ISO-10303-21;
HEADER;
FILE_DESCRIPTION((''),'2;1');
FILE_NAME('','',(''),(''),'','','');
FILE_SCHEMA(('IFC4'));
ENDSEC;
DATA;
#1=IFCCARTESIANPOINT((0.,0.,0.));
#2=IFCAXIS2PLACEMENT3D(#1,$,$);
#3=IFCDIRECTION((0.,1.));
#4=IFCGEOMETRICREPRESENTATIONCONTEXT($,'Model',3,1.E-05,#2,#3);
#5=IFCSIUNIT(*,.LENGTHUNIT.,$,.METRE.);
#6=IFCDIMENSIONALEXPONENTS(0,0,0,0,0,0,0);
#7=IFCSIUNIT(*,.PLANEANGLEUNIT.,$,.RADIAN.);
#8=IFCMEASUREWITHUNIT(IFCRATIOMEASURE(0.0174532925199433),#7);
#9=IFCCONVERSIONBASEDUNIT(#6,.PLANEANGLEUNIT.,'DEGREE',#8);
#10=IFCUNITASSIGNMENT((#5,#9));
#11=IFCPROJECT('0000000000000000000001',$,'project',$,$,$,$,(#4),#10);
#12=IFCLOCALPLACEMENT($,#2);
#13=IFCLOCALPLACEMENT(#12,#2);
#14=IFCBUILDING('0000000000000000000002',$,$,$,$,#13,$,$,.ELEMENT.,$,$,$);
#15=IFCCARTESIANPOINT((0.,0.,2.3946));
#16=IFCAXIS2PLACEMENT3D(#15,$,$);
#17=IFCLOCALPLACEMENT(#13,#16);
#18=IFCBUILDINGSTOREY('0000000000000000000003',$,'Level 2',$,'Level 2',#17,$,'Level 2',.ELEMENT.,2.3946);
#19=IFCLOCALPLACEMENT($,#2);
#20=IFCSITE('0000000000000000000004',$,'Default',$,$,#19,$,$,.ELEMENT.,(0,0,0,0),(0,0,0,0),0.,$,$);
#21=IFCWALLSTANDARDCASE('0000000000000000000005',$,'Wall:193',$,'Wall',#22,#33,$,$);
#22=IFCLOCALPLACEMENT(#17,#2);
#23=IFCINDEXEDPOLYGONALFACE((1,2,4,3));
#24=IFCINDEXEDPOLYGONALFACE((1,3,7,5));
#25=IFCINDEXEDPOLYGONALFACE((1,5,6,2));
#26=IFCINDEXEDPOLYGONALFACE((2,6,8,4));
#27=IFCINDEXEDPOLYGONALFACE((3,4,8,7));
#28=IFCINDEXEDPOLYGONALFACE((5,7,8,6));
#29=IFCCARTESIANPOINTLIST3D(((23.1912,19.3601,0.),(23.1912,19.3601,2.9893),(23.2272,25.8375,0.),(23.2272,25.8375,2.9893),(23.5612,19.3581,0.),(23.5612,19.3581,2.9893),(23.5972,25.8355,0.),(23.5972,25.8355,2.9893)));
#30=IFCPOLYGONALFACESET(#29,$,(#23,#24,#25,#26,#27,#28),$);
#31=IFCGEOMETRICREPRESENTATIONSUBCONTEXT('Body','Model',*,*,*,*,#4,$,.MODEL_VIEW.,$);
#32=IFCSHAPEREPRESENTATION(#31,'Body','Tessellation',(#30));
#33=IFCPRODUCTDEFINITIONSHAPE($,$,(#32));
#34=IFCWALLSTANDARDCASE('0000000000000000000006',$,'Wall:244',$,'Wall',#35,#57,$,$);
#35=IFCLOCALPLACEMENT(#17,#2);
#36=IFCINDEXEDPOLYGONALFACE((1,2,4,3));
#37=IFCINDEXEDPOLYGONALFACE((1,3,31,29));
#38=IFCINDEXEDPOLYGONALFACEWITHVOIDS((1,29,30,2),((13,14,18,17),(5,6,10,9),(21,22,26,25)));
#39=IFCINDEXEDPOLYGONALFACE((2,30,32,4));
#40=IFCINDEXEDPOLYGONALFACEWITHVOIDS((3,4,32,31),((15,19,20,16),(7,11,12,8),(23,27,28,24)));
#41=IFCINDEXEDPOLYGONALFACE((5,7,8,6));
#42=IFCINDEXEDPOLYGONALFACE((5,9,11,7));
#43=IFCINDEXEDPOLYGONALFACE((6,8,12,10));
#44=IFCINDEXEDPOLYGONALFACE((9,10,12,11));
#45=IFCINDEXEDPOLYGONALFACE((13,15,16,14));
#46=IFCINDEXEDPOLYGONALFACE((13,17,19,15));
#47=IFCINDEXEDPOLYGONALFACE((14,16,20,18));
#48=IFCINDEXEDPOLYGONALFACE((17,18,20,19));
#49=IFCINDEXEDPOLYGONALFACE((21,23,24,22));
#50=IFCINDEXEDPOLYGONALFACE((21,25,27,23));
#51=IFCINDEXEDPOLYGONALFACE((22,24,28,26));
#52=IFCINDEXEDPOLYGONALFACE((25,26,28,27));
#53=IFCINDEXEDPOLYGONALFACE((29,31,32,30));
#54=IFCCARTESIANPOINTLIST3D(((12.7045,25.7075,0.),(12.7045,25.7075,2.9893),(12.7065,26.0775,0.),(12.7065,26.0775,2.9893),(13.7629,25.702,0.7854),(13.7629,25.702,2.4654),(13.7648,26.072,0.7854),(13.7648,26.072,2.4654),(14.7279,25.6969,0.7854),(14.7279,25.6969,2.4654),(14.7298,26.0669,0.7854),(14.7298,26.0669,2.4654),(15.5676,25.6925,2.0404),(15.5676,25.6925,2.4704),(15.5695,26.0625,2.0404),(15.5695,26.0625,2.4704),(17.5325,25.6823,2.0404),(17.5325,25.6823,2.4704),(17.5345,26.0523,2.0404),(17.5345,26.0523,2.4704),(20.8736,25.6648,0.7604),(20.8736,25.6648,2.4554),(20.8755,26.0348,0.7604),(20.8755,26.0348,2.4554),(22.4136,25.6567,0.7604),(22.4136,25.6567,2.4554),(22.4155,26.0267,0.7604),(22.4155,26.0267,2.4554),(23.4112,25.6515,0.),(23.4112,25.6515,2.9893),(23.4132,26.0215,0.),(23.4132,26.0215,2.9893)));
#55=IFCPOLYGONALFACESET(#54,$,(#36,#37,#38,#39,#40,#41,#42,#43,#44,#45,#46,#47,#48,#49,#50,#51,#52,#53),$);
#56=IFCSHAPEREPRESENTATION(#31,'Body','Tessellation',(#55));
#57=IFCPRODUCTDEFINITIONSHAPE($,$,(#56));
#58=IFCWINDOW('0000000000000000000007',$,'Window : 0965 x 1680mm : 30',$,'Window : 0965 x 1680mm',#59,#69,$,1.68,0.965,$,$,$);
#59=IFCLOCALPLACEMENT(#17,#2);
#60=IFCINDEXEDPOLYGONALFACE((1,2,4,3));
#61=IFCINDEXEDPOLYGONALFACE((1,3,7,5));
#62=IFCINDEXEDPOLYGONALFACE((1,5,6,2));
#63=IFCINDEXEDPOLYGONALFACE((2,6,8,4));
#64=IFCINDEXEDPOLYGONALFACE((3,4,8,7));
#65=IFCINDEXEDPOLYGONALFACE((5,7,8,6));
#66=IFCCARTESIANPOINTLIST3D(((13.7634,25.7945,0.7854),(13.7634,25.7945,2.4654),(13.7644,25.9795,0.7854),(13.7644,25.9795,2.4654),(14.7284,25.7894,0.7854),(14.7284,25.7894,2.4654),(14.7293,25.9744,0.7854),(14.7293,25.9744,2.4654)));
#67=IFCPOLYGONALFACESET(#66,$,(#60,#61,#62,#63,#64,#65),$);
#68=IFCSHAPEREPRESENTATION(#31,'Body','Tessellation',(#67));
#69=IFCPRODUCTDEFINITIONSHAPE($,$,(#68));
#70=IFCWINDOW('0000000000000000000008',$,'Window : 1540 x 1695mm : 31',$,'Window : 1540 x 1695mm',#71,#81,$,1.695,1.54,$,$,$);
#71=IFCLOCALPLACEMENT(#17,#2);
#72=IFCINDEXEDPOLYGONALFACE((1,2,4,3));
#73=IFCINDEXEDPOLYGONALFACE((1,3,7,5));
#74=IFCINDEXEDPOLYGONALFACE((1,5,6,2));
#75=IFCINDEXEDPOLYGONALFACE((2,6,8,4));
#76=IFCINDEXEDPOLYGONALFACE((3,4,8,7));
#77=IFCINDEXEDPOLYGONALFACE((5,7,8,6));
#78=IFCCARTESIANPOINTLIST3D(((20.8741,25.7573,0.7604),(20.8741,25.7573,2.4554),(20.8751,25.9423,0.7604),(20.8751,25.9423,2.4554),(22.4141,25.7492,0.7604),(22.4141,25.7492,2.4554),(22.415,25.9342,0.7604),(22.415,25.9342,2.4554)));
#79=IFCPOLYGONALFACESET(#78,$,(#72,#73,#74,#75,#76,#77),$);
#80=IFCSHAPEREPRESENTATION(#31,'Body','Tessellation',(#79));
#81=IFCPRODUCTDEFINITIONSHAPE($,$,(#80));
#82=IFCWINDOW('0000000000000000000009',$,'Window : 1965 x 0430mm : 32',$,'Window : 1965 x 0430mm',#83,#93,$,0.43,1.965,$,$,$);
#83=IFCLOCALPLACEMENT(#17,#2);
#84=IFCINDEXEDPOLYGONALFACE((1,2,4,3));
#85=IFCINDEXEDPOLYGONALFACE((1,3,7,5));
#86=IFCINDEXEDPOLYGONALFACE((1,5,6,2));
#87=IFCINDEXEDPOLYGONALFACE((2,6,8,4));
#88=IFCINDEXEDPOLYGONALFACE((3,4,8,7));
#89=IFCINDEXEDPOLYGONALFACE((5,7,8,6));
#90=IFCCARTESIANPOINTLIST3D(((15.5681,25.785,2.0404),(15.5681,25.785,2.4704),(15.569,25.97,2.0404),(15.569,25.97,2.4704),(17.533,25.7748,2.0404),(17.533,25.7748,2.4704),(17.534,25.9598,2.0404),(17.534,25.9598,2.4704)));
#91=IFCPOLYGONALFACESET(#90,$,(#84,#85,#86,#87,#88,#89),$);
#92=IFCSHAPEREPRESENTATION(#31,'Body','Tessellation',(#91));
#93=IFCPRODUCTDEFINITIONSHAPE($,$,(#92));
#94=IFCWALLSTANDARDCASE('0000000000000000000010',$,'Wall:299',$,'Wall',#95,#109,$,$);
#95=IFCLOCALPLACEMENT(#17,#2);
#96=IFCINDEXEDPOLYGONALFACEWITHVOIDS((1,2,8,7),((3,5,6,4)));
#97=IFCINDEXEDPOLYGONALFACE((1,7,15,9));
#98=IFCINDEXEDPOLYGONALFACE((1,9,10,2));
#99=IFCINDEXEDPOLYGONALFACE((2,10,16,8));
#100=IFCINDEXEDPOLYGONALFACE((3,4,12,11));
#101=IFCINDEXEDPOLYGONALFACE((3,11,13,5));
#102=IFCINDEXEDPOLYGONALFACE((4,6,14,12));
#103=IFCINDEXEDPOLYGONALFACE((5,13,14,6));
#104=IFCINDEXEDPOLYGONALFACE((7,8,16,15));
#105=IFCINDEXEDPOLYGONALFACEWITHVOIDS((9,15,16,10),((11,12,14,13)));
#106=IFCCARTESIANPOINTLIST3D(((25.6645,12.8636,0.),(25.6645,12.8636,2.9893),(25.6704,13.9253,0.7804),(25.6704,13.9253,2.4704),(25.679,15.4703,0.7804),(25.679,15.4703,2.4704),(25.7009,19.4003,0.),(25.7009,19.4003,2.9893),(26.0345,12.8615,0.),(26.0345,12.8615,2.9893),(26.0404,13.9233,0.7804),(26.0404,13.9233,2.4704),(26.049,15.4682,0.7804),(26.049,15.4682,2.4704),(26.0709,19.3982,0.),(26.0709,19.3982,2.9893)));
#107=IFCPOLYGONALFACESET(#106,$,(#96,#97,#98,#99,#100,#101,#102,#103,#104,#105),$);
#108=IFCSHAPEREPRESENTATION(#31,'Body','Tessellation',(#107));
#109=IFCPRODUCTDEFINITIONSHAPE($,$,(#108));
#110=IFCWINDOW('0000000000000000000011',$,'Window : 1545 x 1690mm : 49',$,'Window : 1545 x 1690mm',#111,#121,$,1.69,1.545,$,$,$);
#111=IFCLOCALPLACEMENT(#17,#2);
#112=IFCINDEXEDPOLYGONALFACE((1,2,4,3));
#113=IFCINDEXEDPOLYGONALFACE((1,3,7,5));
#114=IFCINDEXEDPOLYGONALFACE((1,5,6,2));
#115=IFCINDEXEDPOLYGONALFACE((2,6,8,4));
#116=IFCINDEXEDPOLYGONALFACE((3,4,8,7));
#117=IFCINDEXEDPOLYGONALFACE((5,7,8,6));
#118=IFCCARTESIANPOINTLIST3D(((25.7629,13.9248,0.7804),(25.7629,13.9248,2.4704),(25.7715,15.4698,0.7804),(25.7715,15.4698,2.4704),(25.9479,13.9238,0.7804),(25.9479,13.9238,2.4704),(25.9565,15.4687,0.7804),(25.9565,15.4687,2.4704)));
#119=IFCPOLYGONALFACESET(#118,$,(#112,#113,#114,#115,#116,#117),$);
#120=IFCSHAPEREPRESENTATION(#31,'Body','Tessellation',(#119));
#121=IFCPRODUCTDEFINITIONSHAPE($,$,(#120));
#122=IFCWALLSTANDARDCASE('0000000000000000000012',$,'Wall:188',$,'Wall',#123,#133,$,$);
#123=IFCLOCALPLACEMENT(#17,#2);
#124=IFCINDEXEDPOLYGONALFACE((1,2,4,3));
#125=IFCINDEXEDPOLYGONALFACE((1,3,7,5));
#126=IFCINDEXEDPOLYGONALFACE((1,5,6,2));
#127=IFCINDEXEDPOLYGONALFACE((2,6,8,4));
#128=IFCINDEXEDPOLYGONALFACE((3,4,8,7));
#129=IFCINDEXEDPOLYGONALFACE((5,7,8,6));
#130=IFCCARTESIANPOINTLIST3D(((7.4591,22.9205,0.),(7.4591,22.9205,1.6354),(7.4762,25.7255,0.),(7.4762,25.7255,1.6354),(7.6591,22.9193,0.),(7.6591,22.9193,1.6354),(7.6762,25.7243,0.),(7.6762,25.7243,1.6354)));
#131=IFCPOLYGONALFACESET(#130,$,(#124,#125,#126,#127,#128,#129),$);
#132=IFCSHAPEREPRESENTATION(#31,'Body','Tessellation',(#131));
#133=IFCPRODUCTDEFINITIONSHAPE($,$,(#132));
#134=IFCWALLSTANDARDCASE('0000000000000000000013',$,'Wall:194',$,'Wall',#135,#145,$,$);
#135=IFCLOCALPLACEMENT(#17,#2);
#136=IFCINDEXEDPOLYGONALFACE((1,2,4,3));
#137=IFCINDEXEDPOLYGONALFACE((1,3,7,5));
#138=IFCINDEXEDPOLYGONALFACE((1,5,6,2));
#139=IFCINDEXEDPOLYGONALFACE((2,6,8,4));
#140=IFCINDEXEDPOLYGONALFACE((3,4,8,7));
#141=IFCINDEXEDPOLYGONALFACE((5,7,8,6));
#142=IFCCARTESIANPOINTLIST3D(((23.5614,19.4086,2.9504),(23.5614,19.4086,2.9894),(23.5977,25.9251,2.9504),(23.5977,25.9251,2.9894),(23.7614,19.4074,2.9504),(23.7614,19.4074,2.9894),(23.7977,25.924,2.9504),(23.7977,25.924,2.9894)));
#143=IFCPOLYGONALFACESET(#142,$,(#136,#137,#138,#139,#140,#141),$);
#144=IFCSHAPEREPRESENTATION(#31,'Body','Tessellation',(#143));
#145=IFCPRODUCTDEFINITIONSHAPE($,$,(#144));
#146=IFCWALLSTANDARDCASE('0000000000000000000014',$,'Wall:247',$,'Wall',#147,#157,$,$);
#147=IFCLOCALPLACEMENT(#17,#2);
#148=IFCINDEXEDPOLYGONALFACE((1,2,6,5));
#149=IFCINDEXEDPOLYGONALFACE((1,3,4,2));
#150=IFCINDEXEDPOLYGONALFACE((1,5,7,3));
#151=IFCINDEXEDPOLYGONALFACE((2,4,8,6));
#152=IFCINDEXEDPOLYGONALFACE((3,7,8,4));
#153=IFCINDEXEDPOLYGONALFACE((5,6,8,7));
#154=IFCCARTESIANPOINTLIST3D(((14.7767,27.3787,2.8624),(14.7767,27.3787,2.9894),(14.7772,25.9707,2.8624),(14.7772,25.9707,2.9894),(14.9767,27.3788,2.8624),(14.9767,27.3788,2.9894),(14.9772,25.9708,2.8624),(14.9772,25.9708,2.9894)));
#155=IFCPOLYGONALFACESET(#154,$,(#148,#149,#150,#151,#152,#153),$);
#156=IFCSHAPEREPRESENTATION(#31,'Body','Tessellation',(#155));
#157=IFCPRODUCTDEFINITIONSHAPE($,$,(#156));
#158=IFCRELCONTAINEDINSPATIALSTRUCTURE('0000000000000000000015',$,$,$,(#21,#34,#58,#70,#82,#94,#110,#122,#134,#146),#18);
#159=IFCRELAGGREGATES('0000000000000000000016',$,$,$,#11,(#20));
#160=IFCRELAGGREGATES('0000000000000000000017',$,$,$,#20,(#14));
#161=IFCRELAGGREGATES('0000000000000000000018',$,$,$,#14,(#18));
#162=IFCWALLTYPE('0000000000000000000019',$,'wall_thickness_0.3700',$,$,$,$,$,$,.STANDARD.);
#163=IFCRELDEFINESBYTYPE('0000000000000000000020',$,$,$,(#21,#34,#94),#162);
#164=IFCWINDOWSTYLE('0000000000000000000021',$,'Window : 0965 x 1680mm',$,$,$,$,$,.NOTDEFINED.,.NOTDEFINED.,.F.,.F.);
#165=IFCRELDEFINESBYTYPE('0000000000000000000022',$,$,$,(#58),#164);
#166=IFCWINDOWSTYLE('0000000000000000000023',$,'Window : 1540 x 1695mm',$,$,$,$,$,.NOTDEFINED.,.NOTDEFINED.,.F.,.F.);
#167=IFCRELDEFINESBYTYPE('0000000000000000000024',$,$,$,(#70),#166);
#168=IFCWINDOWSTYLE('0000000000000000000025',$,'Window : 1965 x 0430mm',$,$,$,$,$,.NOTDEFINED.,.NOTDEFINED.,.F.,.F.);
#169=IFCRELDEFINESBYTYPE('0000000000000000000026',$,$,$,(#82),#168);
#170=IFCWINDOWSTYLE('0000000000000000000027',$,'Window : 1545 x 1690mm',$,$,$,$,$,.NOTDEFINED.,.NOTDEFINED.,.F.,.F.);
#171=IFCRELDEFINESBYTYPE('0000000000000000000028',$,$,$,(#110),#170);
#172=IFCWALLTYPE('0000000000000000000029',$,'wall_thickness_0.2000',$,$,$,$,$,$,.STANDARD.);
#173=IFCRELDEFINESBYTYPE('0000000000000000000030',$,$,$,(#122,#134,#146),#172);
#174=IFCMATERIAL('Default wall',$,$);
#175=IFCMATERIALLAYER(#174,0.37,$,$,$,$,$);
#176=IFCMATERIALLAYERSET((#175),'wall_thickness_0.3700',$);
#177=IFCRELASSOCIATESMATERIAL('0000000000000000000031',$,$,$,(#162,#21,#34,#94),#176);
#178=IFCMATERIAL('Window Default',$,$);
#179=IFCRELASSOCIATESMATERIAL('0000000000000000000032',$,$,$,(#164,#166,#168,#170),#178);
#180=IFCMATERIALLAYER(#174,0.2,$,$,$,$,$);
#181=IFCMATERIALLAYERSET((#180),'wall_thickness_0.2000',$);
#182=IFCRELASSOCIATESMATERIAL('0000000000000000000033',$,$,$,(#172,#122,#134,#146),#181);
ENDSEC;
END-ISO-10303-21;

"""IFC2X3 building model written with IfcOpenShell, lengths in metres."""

from ifc_helpers import new_model, entity, si_unit, converted_unit, direction, frame, frame_2d, origin, origin_2d_with_axis, place, context, subcontext, project, spatial, polyline, rectangle, outline, extrude, source, transform, mapped, material, layer, layer_set, layer_usage, type_object, type_shapes, element, fill, save


model = new_model("IFC2X3")

# Units and contexts
model_context = context("Model", 3, precision=1e-05, world=origin(), true_north=direction((0.0, 1.0)))
body_context = subcontext(model_context, "Body", "Model", "MODEL_VIEW")
ifc_project = project(units=[si_unit("LENGTHUNIT", "METRE"), converted_unit("PLANEANGLEUNIT", "DEGREE", entity("IfcRatioMeasure", 0.0174532925199433), si_unit("PLANEANGLEUNIT", "RADIAN"), dimensions=[0, 0, 0, 0, 0, 0, 0])], contexts=[model_context])

# Site, building, storey
site_placement = place(None, origin())
site = spatial("IfcSite", under=ifc_project, at=site_placement, Name="Default", CompositionType="ELEMENT", RefLatitude=(0, 0, 0, 0), RefLongitude=(0, 0, 0, 0), RefElevation=0.0)
placement_1 = place(None, origin())
building_placement = place(placement_1, origin())
building = spatial("IfcBuilding", under=site, at=building_placement, CompositionType="ELEMENT")
storey_placement = place(building_placement, frame((0.0, 0.0, 2.3946)))
storey = spatial("IfcBuildingStorey", under=building, at=storey_placement, Name="Level 2", ObjectType="Level 2", LongName="Level 2", CompositionType="ELEMENT", Elevation=2.3946)

# Wall
ifc_material_1 = material(Name="Default wall")
ifc_layer_1 = layer(ifc_material_1, 0.37)
ifc_layer_set_1 = layer_set([ifc_layer_1], Name="wall_thickness_0.3700")
ifc_layer_usage_1 = layer_usage(ifc_layer_set_1, "AXIS2", "POSITIVE", -0.185)
wall_type_1 = type_object("IfcWallType", Name="wall_thickness_0.3700", PredefinedType="STANDARD", material=ifc_layer_set_1)
wall_1_placement = place(storey_placement, frame((23.4122, 25.8365, 0.0), z_axis=(0.0, 0.0, 1.0), x_axis=(-0.005562, -0.999985, 0.0)))
element("IfcWallStandardCase", 1, at=wall_1_placement, inside=storey, type_object=wall_type_1, material=ifc_layer_usage_1, Name="Wall:193", ObjectType="Wall", context=body_context, shape_type="SweptSolid", body=[
    extrude(outline(polyline([(6.4775, -0.185), (6.4775, 0.185), (0.0, 0.185), (0.0, -0.185), (6.4775, -0.185)])), origin(), (0.0, 0.0, 1.0), 2.9893),
])

# Wall, openings, windows
wall_2_placement = place(storey_placement, frame((12.7055, 25.8925, 0.0), z_axis=(0.0, 0.0, 1.0), x_axis=(0.999986, -0.005235, 0.0)))
wall_2 = element("IfcWallStandardCase", 2, at=wall_2_placement, inside=storey, type_object=wall_type_1, material=ifc_layer_usage_1, Name="Wall:244", ObjectType="Wall", context=body_context, shape_type="SweptSolid", body=[
    extrude(outline(polyline([(10.7069, -0.185), (10.7069, 0.185), (0.0, 0.185), (0.0, -0.185), (10.7069, -0.185)])), origin(), (0.0, 0.0, 1.0), 2.9893),
])
opening_1_placement = place(wall_2_placement, frame((1.0584, -0.185, 0.7854)))
opening_1 = element("IfcOpeningElement", 3, at=opening_1_placement, cuts=wall_2, ObjectType="Opening", context=body_context, shape_type="SweptSolid", body=[
    extrude(rectangle(XDim=0.965, YDim=1.68, at=frame_2d((0.84, 0.4825), x_axis=(0.0, 1.0))), frame((0.0, 0.0, 0.0), z_axis=(0.0, 1.0, 0.0), x_axis=(0.0, 0.0, 1.0)), (0.0, 0.0, 1.0), 0.37),
])
opening_2_placement = place(wall_2_placement, frame((8.1692, -0.185, 0.7604)))
opening_2 = element("IfcOpeningElement", 4, at=opening_2_placement, cuts=wall_2, ObjectType="Opening", context=body_context, shape_type="SweptSolid", body=[
    extrude(rectangle(XDim=1.54, YDim=1.695, at=frame_2d((0.8475, 0.77), x_axis=(0.0, 1.0))), frame((0.0, 0.0, 0.0), z_axis=(0.0, 1.0, 0.0), x_axis=(0.0, 0.0, 1.0)), (0.0, 0.0, 1.0), 0.37),
])
opening_3_placement = place(wall_2_placement, frame((2.8631, -0.185, 2.0404)))
opening_3 = element("IfcOpeningElement", 5, at=opening_3_placement, cuts=wall_2, ObjectType="Opening", context=body_context, shape_type="SweptSolid", body=[
    extrude(rectangle(XDim=1.965, YDim=0.43, at=frame_2d((0.215, 0.9825), x_axis=(0.0, 1.0))), frame((0.0, 0.0, 0.0), z_axis=(0.0, 1.0, 0.0), x_axis=(0.0, 0.0, 1.0)), (0.0, 0.0, 1.0), 0.37),
])
ifc_material_2 = material(Name="Window Default")
window_style_1 = type_object("IfcWindowStyle", Name="Window : 0965 x 1680mm", ConstructionType="NOTDEFINED", OperationType="NOTDEFINED", ParameterTakesPrecedence=False, Sizeable=False, material=ifc_material_2)
shared_shape_1 = source(origin(), body_context, "Body", "SweptSolid", [
    extrude(rectangle(XDim=0.185, YDim=0.965, at=origin_2d_with_axis()), frame((0.4825, 0.185, 0.0), z_axis=(0.0, 0.0, 1.0), x_axis=(0.0, 1.0, 0.0)), (0.0, 0.0, 1.0), 1.68),
])
type_shapes(window_style_1, [shared_shape_1])
window_1_placement = place(opening_1_placement, origin())
window_1 = element("IfcWindow", 6, at=window_1_placement, inside=storey, type_object=window_style_1, Name="Window : 0965 x 1680mm : 30", ObjectType="Window : 0965 x 1680mm", OverallHeight=1.68, OverallWidth=0.965, context=body_context, shape_type="MappedRepresentation", body=[
    mapped(shared_shape_1, transform((0.0, 0.0, 0.0), scale=1.0)),
])
fill(opening_1, window_1)
window_style_2 = type_object("IfcWindowStyle", Name="Window : 1540 x 1695mm", ConstructionType="NOTDEFINED", OperationType="NOTDEFINED", ParameterTakesPrecedence=False, Sizeable=False, material=ifc_material_2)
shared_shape_2 = source(origin(), body_context, "Body", "SweptSolid", [
    extrude(rectangle(XDim=0.185, YDim=1.54, at=origin_2d_with_axis()), frame((0.77, 0.185, 0.0), z_axis=(0.0, 0.0, 1.0), x_axis=(0.0, 1.0, 0.0)), (0.0, 0.0, 1.0), 1.695),
])
type_shapes(window_style_2, [shared_shape_2])
window_2_placement = place(opening_2_placement, origin())
window_2 = element("IfcWindow", 7, at=window_2_placement, inside=storey, type_object=window_style_2, Name="Window : 1540 x 1695mm : 31", ObjectType="Window : 1540 x 1695mm", OverallHeight=1.695, OverallWidth=1.54, context=body_context, shape_type="MappedRepresentation", body=[
    mapped(shared_shape_2, transform((0.0, 0.0, 0.0), scale=1.0)),
])
fill(opening_2, window_2)
window_style_3 = type_object("IfcWindowStyle", Name="Window : 1965 x 0430mm", ConstructionType="NOTDEFINED", OperationType="NOTDEFINED", ParameterTakesPrecedence=False, Sizeable=False, material=ifc_material_2)
shared_shape_3 = source(origin(), body_context, "Body", "SweptSolid", [
    extrude(rectangle(XDim=0.185, YDim=1.965, at=origin_2d_with_axis()), frame((0.9825, 0.185, 0.0), z_axis=(0.0, 0.0, 1.0), x_axis=(0.0, 1.0, 0.0)), (0.0, 0.0, 1.0), 0.43),
])
type_shapes(window_style_3, [shared_shape_3])
window_3_placement = place(opening_3_placement, origin())
window_3 = element("IfcWindow", 8, at=window_3_placement, inside=storey, type_object=window_style_3, Name="Window : 1965 x 0430mm : 32", ObjectType="Window : 1965 x 0430mm", OverallHeight=0.43, OverallWidth=1.965, context=body_context, shape_type="MappedRepresentation", body=[
    mapped(shared_shape_3, transform((0.0, 0.0, 0.0), scale=1.0)),
])
fill(opening_3, window_3)

# Wall, opening, window
wall_3_placement = place(storey_placement, frame((25.8859, 19.3992, 0.0), z_axis=(0.0, 0.0, 1.0), x_axis=(-0.005566, -0.999985, 0.0)))
wall_3 = element("IfcWallStandardCase", 9, at=wall_3_placement, inside=storey, type_object=wall_type_1, material=ifc_layer_usage_1, Name="Wall:299", ObjectType="Wall", context=body_context, shape_type="SweptSolid", body=[
    extrude(outline(polyline([(6.5368, -0.185), (6.5368, 0.185), (0.0, 0.185), (0.0, -0.185), (6.5368, -0.185)])), origin(), (0.0, 0.0, 1.0), 2.9893),
])
opening_4_placement = place(wall_3_placement, frame((3.93, -0.185, 0.7804)))
opening_4 = element("IfcOpeningElement", 10, at=opening_4_placement, cuts=wall_3, ObjectType="Opening", context=body_context, shape_type="SweptSolid", body=[
    extrude(rectangle(XDim=1.545, YDim=1.69, at=frame_2d((0.845, 0.7725), x_axis=(0.0, 1.0))), frame((0.0, 0.0, 0.0), z_axis=(0.0, 1.0, 0.0), x_axis=(0.0, 0.0, 1.0)), (0.0, 0.0, 1.0), 0.37),
])
window_style_4 = type_object("IfcWindowStyle", Name="Window : 1545 x 1690mm", ConstructionType="NOTDEFINED", OperationType="NOTDEFINED", ParameterTakesPrecedence=False, Sizeable=False, material=ifc_material_2)
shared_shape_4 = source(origin(), body_context, "Body", "SweptSolid", [
    extrude(rectangle(XDim=0.185, YDim=1.545, at=origin_2d_with_axis()), frame((0.7725, 0.185, 0.0), z_axis=(0.0, 0.0, 1.0), x_axis=(0.0, 1.0, 0.0)), (0.0, 0.0, 1.0), 1.69),
])
type_shapes(window_style_4, [shared_shape_4])
window_4_placement = place(opening_4_placement, origin())
window_4 = element("IfcWindow", 11, at=window_4_placement, inside=storey, type_object=window_style_4, Name="Window : 1545 x 1690mm : 49", ObjectType="Window : 1545 x 1690mm", OverallHeight=1.69, OverallWidth=1.545, context=body_context, shape_type="MappedRepresentation", body=[
    mapped(shared_shape_4, transform((0.0, 0.0, 0.0), scale=1.0)),
])
fill(opening_4, window_4)

# Walls
ifc_layer_2 = layer(ifc_material_1, 0.2)
ifc_layer_set_2 = layer_set([ifc_layer_2], Name="wall_thickness_0.2000")
ifc_layer_usage_2 = layer_usage(ifc_layer_set_2, "AXIS2", "POSITIVE", -0.1)
wall_type_2 = type_object("IfcWallType", Name="wall_thickness_0.2000", PredefinedType="STANDARD", material=ifc_layer_set_2)
wall_4_placement = place(storey_placement, frame((7.5591, 22.9199, 0.0), z_axis=(0.0, 0.0, 1.0), x_axis=(0.006081, 0.999982, 0.0)))
element("IfcWallStandardCase", 12, at=wall_4_placement, inside=storey, type_object=wall_type_2, material=ifc_layer_usage_2, Name="Wall:188", ObjectType="Wall", context=body_context, shape_type="SweptSolid", body=[
    extrude(outline(polyline([(2.805, -0.1), (2.805, 0.1), (0.0, 0.1), (0.0, -0.1), (2.805, -0.1)])), origin(), (0.0, 0.0, 1.0), 1.6354),
])
placement_2 = place(building_placement, frame((0.0, 0.0, 5.345)))
wall_5_placement = place(placement_2, frame((23.6977, 25.9246, 0.0), z_axis=(0.0, 0.0, 1.0), x_axis=(-0.005563, -0.999985, 0.0)))
element("IfcWallStandardCase", 13, at=wall_5_placement, inside=storey, type_object=wall_type_2, material=ifc_layer_usage_2, Name="Wall:194", ObjectType="Wall", context=body_context, shape_type="SweptSolid", body=[
    extrude(outline(polyline([(6.5167, -0.1), (6.5167, 0.1), (0.0, 0.1), (0.0, -0.1), (6.5167, -0.1)])), origin(), (0.0, 0.0, 1.0), 0.039),
])
placement_3 = place(building_placement, frame((0.0, 0.0, 5.257)))
wall_6_placement = place(placement_3, frame((14.8772, 25.9707, 0.0), z_axis=(0.0, 0.0, 1.0), x_axis=(-0.000386, 1.0, 0.0)))
element("IfcWallStandardCase", 14, at=wall_6_placement, inside=storey, type_object=wall_type_2, material=ifc_layer_usage_2, Name="Wall:247", ObjectType="Wall", context=body_context, shape_type="SweptSolid", body=[
    extrude(outline(polyline([(1.408, -0.1), (1.408, 0.1), (0.0, 0.1), (0.0, -0.1), (1.408, -0.1)])), origin(), (0.0, 0.0, 1.0), 0.127),
])

save(model, "model.ifc")
